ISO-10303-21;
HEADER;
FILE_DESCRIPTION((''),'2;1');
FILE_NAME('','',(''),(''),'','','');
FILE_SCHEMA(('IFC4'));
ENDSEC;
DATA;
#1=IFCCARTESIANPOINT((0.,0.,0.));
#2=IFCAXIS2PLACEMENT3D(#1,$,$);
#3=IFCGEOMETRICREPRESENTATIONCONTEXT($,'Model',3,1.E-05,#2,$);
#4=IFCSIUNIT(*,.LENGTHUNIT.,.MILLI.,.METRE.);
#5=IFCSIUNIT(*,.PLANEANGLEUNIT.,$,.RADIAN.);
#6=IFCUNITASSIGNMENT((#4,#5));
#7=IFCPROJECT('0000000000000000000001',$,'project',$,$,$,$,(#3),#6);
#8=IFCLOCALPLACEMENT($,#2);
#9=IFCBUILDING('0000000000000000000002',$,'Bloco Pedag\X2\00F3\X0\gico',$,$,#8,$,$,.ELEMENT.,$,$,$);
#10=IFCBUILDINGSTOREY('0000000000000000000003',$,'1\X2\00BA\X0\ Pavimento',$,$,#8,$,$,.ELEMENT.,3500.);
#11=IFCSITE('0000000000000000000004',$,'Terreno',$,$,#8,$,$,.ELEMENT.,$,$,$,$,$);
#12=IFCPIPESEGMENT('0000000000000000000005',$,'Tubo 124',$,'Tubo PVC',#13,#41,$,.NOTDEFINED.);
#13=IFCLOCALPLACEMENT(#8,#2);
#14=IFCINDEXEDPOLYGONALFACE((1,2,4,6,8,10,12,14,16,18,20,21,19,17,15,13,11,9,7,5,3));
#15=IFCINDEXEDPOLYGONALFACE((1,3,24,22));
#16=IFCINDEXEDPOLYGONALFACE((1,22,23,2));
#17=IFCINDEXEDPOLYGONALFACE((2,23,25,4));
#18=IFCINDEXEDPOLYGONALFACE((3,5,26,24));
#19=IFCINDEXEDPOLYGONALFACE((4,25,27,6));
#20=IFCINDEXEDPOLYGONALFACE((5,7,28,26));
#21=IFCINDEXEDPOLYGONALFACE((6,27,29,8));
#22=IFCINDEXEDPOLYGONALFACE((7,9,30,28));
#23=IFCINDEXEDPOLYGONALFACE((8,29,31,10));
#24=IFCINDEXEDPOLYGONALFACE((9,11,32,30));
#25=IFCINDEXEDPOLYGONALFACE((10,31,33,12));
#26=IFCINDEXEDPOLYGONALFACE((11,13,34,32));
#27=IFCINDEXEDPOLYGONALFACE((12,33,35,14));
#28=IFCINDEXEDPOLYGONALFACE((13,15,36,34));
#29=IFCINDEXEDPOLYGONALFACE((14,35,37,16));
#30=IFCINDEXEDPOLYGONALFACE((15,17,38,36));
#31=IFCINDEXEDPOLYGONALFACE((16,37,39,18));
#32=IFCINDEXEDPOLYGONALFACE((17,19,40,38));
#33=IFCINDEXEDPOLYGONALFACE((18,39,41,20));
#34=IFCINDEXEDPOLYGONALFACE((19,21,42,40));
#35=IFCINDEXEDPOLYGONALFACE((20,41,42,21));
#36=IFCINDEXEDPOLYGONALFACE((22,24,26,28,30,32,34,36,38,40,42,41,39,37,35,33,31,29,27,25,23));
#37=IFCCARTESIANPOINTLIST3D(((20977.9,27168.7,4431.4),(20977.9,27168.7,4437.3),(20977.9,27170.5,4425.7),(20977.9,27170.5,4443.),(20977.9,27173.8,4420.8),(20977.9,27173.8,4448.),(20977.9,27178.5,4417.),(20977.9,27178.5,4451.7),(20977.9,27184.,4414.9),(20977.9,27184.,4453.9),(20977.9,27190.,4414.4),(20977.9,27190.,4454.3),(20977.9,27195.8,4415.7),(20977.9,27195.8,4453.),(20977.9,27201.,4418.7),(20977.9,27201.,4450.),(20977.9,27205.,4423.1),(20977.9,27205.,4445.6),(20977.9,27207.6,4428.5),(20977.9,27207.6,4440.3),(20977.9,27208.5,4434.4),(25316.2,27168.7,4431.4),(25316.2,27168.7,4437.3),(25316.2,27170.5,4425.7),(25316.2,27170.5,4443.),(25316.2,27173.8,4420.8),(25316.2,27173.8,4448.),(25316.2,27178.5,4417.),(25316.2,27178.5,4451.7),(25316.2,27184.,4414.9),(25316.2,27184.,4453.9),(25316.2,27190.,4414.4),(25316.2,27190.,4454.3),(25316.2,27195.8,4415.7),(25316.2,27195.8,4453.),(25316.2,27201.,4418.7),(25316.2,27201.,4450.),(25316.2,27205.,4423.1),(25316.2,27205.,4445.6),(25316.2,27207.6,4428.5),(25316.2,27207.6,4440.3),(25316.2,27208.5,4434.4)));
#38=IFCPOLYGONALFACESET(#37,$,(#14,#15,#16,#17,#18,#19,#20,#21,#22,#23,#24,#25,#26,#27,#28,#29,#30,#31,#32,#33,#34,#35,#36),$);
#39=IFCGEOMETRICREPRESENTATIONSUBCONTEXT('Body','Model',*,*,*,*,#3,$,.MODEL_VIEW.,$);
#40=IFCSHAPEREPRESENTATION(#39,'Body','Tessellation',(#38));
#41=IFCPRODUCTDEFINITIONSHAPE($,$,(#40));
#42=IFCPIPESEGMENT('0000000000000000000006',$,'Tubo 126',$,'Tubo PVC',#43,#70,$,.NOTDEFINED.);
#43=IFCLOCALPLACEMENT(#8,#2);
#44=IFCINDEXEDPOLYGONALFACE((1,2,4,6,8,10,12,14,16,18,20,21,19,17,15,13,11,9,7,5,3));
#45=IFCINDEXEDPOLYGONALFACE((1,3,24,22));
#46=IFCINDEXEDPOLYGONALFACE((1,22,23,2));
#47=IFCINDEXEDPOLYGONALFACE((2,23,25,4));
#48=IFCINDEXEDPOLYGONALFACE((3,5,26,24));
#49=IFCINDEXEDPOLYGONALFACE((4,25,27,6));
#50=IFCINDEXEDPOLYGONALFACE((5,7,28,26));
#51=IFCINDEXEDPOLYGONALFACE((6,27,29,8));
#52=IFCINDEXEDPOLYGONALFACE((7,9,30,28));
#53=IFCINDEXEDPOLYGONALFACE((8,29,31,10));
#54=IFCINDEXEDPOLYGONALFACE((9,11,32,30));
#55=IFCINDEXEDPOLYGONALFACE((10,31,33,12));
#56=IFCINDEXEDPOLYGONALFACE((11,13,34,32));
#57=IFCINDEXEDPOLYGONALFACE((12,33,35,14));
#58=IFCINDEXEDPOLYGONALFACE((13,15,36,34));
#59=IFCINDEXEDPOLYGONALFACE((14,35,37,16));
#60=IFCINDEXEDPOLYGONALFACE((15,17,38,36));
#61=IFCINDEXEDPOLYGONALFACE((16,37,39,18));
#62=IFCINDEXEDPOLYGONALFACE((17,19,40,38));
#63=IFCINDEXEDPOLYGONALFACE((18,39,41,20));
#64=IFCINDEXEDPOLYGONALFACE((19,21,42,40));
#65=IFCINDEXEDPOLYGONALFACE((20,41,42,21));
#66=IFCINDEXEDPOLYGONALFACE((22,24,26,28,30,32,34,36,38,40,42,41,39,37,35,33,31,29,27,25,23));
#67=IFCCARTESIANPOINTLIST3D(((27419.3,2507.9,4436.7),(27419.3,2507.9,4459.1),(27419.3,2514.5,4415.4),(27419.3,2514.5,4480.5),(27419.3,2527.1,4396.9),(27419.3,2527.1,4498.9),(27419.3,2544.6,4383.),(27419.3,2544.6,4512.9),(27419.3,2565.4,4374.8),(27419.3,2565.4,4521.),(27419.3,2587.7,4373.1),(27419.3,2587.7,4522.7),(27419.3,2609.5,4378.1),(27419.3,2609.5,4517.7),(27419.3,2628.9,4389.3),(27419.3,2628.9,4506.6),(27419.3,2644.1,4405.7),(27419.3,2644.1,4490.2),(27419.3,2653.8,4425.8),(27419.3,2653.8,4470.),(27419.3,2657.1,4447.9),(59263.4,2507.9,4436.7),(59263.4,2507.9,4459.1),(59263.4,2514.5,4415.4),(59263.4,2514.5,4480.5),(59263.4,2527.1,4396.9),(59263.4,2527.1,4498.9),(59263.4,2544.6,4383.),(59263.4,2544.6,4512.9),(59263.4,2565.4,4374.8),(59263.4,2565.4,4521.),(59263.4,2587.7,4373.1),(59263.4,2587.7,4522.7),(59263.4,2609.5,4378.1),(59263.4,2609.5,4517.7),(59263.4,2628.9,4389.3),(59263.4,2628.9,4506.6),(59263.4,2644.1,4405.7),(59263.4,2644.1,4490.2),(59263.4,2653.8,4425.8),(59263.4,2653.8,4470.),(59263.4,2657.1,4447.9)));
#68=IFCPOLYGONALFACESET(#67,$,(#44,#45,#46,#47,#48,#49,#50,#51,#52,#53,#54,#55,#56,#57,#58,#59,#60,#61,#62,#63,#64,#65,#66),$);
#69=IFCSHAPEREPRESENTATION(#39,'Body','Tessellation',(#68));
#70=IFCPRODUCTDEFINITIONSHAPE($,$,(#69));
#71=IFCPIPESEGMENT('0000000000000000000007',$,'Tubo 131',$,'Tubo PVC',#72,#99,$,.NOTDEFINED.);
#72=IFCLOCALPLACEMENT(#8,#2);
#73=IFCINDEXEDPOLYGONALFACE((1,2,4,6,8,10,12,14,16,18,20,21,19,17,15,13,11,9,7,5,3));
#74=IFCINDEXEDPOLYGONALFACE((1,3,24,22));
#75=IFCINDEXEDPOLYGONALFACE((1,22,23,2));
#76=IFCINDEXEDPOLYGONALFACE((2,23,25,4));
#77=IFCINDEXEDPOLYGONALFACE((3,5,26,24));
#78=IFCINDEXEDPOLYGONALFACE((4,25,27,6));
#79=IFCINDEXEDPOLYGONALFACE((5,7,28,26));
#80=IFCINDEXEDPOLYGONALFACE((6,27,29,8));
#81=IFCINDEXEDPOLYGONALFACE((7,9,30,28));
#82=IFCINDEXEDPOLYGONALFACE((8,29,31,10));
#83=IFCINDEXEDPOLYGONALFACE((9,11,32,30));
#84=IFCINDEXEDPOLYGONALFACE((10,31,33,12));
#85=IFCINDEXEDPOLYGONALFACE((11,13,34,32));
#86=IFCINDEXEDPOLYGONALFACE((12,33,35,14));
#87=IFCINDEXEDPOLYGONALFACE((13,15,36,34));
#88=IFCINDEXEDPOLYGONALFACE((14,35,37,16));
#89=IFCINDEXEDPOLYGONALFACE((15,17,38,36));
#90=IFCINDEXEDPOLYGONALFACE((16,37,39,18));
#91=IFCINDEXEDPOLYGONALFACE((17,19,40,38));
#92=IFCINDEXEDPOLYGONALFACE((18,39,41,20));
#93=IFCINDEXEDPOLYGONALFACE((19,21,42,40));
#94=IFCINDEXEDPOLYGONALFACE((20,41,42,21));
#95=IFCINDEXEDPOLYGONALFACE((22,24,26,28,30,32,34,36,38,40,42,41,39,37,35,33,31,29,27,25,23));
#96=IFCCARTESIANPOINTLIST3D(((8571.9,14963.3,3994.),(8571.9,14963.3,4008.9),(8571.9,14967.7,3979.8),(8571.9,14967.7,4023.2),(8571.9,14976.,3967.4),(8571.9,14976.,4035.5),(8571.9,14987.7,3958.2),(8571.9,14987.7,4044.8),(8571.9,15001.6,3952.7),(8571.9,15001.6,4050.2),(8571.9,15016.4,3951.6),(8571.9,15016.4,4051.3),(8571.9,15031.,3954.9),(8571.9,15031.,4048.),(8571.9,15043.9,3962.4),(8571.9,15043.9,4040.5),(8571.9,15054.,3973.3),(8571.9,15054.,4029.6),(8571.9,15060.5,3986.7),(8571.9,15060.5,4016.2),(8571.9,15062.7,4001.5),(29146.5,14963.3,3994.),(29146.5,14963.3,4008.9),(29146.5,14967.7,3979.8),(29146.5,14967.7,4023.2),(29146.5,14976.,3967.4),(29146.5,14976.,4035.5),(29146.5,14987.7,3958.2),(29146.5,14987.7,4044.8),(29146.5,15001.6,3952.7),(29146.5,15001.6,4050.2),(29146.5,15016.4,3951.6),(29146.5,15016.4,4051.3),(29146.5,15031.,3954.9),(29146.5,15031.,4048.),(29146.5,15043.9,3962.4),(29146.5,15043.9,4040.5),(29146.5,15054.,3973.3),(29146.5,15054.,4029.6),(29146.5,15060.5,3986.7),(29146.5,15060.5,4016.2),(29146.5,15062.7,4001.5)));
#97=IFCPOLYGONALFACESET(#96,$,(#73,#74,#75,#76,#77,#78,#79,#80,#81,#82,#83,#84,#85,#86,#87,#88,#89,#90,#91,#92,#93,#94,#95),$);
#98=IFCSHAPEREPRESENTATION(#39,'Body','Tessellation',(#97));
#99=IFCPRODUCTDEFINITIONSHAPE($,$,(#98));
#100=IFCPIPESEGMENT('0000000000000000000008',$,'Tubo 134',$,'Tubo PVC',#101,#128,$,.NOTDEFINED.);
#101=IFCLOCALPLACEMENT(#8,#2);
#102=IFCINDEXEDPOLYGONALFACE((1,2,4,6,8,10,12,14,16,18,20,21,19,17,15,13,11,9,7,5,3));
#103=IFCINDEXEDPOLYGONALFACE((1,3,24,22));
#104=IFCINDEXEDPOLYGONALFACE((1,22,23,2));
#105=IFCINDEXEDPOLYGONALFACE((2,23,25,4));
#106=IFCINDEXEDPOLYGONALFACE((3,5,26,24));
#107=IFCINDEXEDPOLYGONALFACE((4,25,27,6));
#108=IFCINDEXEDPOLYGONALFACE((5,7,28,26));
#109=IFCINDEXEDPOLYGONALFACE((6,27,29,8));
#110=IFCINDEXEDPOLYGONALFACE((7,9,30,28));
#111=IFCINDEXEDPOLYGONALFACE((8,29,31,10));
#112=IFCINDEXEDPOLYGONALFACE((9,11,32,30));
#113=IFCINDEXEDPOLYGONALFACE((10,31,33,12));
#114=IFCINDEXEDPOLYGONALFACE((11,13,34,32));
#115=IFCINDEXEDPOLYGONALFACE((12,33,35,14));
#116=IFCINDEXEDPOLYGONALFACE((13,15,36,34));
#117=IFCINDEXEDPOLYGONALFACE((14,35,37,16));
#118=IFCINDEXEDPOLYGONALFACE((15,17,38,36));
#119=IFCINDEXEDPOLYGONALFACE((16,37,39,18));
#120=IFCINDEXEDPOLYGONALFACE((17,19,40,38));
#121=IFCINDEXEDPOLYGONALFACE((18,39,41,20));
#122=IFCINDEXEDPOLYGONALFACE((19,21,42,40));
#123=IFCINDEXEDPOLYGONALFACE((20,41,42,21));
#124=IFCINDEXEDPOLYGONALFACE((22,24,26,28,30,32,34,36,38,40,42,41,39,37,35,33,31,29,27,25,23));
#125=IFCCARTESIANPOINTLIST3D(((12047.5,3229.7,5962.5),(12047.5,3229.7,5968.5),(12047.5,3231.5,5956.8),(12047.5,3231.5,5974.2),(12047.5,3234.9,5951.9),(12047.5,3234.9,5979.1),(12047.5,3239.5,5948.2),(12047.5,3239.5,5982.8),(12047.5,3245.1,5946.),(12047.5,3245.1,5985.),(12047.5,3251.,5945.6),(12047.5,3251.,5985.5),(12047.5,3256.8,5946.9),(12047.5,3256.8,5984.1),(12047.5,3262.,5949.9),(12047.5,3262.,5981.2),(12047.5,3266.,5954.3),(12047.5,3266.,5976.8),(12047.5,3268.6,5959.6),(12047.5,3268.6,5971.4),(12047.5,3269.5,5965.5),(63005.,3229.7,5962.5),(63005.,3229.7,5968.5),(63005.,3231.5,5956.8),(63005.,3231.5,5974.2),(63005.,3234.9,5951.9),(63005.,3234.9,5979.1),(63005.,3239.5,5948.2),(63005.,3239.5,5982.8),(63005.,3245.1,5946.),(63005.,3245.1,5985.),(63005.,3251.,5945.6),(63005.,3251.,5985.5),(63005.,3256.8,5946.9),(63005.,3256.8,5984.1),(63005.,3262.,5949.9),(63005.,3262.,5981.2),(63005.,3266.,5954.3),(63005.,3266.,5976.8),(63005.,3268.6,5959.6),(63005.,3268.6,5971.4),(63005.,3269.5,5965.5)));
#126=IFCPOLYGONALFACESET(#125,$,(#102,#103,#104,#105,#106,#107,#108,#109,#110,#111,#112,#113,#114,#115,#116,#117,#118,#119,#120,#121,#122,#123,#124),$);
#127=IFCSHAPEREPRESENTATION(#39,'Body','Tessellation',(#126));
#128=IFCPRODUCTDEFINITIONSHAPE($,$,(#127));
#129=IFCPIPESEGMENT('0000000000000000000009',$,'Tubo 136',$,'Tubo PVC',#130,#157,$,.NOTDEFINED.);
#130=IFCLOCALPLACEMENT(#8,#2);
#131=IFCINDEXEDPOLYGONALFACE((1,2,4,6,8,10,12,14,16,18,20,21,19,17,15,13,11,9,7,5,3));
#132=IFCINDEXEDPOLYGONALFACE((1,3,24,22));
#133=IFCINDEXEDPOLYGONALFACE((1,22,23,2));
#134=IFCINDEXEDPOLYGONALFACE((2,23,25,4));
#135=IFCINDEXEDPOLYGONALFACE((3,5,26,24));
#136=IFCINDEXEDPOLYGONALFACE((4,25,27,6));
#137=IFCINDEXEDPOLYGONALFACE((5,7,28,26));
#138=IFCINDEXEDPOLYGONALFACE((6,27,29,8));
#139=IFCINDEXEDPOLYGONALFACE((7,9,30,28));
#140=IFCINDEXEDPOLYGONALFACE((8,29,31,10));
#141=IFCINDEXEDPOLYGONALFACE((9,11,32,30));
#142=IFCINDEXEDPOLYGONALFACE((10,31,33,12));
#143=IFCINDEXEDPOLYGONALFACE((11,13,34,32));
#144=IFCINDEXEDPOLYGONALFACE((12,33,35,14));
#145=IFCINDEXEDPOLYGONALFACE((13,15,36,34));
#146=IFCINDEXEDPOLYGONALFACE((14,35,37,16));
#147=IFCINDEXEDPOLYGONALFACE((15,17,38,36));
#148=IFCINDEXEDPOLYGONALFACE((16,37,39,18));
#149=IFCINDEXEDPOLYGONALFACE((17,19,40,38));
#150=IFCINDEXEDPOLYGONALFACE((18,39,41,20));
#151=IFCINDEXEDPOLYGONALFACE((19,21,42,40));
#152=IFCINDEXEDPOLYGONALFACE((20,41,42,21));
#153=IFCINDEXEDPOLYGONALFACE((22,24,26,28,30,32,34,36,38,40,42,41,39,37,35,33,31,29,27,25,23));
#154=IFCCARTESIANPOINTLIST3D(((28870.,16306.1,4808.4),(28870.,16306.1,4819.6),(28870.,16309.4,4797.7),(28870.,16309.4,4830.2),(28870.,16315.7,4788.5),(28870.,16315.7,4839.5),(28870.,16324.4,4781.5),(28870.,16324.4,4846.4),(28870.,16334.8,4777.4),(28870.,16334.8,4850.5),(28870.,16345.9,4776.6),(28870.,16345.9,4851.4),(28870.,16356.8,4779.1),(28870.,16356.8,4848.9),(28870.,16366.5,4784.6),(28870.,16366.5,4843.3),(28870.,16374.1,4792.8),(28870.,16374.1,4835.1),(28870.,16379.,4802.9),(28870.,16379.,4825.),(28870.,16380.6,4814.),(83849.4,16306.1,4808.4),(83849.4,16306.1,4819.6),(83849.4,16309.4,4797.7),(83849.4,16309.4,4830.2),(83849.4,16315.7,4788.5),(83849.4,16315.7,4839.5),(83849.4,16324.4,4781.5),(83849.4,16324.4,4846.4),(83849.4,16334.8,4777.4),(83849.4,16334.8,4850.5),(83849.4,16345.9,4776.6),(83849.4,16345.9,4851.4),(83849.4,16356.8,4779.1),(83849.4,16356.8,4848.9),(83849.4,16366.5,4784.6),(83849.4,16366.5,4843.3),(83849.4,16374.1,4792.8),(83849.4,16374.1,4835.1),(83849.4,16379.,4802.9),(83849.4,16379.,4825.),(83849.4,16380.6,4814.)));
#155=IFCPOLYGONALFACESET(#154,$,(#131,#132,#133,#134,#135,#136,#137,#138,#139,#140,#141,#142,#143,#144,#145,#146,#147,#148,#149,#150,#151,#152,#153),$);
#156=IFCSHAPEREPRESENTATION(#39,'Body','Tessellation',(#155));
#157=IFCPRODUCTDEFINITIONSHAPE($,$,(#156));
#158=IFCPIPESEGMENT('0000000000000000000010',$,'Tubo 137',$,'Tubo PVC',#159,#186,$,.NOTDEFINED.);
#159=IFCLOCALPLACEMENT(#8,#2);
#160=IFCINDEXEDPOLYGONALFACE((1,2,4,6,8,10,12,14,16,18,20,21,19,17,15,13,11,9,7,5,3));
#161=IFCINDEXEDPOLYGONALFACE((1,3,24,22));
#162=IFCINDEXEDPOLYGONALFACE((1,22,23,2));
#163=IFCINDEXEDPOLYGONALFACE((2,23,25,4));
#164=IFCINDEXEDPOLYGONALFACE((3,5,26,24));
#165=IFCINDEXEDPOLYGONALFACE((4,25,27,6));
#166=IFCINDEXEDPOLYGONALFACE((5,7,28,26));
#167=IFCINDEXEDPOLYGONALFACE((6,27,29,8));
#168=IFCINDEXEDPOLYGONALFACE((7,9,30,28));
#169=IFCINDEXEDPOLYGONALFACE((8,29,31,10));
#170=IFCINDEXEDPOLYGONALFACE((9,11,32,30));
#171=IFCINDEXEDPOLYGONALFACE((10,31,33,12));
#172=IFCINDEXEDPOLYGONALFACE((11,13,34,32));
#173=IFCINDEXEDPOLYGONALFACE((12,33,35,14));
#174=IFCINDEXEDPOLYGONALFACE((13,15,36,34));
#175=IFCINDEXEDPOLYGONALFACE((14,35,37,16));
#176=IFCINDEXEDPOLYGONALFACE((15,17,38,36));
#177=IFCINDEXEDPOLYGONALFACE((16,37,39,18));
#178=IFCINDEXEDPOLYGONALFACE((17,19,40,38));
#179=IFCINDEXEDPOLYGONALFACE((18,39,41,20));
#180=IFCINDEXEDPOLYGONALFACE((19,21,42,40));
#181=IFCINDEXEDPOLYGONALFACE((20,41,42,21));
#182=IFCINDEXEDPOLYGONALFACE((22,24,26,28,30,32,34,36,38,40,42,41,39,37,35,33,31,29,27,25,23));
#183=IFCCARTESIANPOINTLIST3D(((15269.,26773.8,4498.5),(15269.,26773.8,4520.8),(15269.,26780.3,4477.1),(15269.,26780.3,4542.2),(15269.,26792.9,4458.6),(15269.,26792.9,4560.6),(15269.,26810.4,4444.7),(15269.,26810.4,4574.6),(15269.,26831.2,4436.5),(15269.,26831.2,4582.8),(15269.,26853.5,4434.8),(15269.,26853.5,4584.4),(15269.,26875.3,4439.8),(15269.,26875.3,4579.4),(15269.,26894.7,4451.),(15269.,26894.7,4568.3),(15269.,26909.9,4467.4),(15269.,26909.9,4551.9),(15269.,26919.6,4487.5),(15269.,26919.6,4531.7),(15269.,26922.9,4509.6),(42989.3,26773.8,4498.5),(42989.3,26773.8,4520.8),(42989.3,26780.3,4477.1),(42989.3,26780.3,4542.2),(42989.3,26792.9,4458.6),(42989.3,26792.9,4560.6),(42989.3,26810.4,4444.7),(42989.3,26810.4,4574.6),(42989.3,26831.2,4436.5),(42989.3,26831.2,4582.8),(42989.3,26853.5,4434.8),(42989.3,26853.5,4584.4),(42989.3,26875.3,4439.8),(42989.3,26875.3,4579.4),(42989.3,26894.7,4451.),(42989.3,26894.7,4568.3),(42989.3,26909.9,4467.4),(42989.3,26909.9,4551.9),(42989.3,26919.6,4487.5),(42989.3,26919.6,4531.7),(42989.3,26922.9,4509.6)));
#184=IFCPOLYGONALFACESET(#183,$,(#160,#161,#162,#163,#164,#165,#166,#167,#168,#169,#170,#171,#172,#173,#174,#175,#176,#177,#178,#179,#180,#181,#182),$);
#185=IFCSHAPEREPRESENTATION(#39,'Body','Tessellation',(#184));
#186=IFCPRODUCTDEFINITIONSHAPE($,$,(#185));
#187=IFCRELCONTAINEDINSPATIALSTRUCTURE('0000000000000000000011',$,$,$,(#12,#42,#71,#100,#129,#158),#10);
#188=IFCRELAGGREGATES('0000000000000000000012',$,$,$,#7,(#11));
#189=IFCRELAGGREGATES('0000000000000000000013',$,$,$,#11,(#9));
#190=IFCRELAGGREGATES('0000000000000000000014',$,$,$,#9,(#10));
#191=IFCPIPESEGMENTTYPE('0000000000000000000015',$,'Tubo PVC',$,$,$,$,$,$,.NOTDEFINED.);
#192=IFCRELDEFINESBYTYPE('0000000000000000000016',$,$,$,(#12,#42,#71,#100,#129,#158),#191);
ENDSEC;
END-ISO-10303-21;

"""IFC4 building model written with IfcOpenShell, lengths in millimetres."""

from ifc_helpers import new_model, si_unit, frame, origin, origin_2d, place, context, subcontext, project, spatial, circle, extrude, type_object, element, save


model = new_model("IFC4")

# Units and contexts
model_context = context("Model", 3, precision=1e-05, world=origin())
body_context = subcontext(model_context, "Body", "Model", "MODEL_VIEW")
ifc_project = project(units=[si_unit("LENGTHUNIT", "METRE", prefix="MILLI"), si_unit("PLANEANGLEUNIT", "RADIAN")], contexts=[model_context])

# Site, building, storey
placement = place(None, origin())
site = spatial("IfcSite", under=ifc_project, at=placement, Name="Terreno", CompositionType="ELEMENT")
building = spatial("IfcBuilding", under=site, at=placement, Name="Bloco Pedagógico", CompositionType="ELEMENT")
storey = spatial("IfcBuildingStorey", under=building, at=placement, Name="1º Pavimento", CompositionType="ELEMENT", Elevation=3500.0)

# Pipe segments
pipe_segment_type = type_object("IfcPipeSegmentType", Name="Tubo PVC", PredefinedType="NOTDEFINED")
pipe_segment_1_placement = place(None, frame((20977.9, 27188.5, 4434.4), z_axis=(1.0, 0.0, 0.0), x_axis=(0.0, 1.0, 0.0)))
element("IfcPipeSegment", 1, at=pipe_segment_1_placement, inside=storey, type_object=pipe_segment_type, Name="Tubo 124", ObjectType="Tubo PVC", PredefinedType="NOTDEFINED", context=body_context, shape_type="SweptSolid", body=[
    extrude(circle(Radius=20.0, at=origin_2d()), None, (0.0, 0.0, 1.0), 4338.2),
])
pipe_segment_2_placement = place(None, frame((27419.3, 2582.1, 4447.9), z_axis=(1.0, 0.0, 0.0), x_axis=(0.0, 1.0, 0.0)))
element("IfcPipeSegment", 2, at=pipe_segment_2_placement, inside=storey, type_object=pipe_segment_type, Name="Tubo 126", ObjectType="Tubo PVC", PredefinedType="NOTDEFINED", context=body_context, shape_type="SweptSolid", body=[
    extrude(circle(Radius=75.0, at=origin_2d()), None, (0.0, 0.0, 1.0), 31844.2),
])
pipe_segment_3_placement = place(None, frame((8571.9, 15012.7, 4001.5), z_axis=(1.0, 0.0, 0.0), x_axis=(0.0, 1.0, 0.0)))
element("IfcPipeSegment", 3, at=pipe_segment_3_placement, inside=storey, type_object=pipe_segment_type, Name="Tubo 131", ObjectType="Tubo PVC", PredefinedType="NOTDEFINED", context=body_context, shape_type="SweptSolid", body=[
    extrude(circle(Radius=50.0, at=origin_2d()), None, (0.0, 0.0, 1.0), 20574.6),
])
pipe_segment_4_placement = place(None, frame((12047.5, 3249.5, 5965.5), z_axis=(1.0, 0.0, 0.0), x_axis=(0.0, 1.0, 0.0)))
element("IfcPipeSegment", 4, at=pipe_segment_4_placement, inside=storey, type_object=pipe_segment_type, Name="Tubo 134", ObjectType="Tubo PVC", PredefinedType="NOTDEFINED", context=body_context, shape_type="SweptSolid", body=[
    extrude(circle(Radius=20.0, at=origin_2d()), None, (0.0, 0.0, 1.0), 50957.5),
])
pipe_segment_5_placement = place(None, frame((28870.0, 16343.1, 4814.0), z_axis=(1.0, 0.0, 0.0), x_axis=(0.0, 1.0, 0.0)))
element("IfcPipeSegment", 5, at=pipe_segment_5_placement, inside=storey, type_object=pipe_segment_type, Name="Tubo 136", ObjectType="Tubo PVC", PredefinedType="NOTDEFINED", context=body_context, shape_type="SweptSolid", body=[
    extrude(circle(Radius=37.5, at=origin_2d()), None, (0.0, 0.0, 1.0), 54979.4),
])
pipe_segment_6_placement = place(None, frame((15269.0, 26847.9, 4509.6), z_axis=(1.0, 0.0, 0.0), x_axis=(0.0, 1.0, 0.0)))
element("IfcPipeSegment", 6, at=pipe_segment_6_placement, inside=storey, type_object=pipe_segment_type, Name="Tubo 137", ObjectType="Tubo PVC", PredefinedType="NOTDEFINED", context=body_context, shape_type="SweptSolid", body=[
    extrude(circle(Radius=75.0, at=origin_2d()), None, (0.0, 0.0, 1.0), 27720.3),
])

save(model, "model.ifc")
